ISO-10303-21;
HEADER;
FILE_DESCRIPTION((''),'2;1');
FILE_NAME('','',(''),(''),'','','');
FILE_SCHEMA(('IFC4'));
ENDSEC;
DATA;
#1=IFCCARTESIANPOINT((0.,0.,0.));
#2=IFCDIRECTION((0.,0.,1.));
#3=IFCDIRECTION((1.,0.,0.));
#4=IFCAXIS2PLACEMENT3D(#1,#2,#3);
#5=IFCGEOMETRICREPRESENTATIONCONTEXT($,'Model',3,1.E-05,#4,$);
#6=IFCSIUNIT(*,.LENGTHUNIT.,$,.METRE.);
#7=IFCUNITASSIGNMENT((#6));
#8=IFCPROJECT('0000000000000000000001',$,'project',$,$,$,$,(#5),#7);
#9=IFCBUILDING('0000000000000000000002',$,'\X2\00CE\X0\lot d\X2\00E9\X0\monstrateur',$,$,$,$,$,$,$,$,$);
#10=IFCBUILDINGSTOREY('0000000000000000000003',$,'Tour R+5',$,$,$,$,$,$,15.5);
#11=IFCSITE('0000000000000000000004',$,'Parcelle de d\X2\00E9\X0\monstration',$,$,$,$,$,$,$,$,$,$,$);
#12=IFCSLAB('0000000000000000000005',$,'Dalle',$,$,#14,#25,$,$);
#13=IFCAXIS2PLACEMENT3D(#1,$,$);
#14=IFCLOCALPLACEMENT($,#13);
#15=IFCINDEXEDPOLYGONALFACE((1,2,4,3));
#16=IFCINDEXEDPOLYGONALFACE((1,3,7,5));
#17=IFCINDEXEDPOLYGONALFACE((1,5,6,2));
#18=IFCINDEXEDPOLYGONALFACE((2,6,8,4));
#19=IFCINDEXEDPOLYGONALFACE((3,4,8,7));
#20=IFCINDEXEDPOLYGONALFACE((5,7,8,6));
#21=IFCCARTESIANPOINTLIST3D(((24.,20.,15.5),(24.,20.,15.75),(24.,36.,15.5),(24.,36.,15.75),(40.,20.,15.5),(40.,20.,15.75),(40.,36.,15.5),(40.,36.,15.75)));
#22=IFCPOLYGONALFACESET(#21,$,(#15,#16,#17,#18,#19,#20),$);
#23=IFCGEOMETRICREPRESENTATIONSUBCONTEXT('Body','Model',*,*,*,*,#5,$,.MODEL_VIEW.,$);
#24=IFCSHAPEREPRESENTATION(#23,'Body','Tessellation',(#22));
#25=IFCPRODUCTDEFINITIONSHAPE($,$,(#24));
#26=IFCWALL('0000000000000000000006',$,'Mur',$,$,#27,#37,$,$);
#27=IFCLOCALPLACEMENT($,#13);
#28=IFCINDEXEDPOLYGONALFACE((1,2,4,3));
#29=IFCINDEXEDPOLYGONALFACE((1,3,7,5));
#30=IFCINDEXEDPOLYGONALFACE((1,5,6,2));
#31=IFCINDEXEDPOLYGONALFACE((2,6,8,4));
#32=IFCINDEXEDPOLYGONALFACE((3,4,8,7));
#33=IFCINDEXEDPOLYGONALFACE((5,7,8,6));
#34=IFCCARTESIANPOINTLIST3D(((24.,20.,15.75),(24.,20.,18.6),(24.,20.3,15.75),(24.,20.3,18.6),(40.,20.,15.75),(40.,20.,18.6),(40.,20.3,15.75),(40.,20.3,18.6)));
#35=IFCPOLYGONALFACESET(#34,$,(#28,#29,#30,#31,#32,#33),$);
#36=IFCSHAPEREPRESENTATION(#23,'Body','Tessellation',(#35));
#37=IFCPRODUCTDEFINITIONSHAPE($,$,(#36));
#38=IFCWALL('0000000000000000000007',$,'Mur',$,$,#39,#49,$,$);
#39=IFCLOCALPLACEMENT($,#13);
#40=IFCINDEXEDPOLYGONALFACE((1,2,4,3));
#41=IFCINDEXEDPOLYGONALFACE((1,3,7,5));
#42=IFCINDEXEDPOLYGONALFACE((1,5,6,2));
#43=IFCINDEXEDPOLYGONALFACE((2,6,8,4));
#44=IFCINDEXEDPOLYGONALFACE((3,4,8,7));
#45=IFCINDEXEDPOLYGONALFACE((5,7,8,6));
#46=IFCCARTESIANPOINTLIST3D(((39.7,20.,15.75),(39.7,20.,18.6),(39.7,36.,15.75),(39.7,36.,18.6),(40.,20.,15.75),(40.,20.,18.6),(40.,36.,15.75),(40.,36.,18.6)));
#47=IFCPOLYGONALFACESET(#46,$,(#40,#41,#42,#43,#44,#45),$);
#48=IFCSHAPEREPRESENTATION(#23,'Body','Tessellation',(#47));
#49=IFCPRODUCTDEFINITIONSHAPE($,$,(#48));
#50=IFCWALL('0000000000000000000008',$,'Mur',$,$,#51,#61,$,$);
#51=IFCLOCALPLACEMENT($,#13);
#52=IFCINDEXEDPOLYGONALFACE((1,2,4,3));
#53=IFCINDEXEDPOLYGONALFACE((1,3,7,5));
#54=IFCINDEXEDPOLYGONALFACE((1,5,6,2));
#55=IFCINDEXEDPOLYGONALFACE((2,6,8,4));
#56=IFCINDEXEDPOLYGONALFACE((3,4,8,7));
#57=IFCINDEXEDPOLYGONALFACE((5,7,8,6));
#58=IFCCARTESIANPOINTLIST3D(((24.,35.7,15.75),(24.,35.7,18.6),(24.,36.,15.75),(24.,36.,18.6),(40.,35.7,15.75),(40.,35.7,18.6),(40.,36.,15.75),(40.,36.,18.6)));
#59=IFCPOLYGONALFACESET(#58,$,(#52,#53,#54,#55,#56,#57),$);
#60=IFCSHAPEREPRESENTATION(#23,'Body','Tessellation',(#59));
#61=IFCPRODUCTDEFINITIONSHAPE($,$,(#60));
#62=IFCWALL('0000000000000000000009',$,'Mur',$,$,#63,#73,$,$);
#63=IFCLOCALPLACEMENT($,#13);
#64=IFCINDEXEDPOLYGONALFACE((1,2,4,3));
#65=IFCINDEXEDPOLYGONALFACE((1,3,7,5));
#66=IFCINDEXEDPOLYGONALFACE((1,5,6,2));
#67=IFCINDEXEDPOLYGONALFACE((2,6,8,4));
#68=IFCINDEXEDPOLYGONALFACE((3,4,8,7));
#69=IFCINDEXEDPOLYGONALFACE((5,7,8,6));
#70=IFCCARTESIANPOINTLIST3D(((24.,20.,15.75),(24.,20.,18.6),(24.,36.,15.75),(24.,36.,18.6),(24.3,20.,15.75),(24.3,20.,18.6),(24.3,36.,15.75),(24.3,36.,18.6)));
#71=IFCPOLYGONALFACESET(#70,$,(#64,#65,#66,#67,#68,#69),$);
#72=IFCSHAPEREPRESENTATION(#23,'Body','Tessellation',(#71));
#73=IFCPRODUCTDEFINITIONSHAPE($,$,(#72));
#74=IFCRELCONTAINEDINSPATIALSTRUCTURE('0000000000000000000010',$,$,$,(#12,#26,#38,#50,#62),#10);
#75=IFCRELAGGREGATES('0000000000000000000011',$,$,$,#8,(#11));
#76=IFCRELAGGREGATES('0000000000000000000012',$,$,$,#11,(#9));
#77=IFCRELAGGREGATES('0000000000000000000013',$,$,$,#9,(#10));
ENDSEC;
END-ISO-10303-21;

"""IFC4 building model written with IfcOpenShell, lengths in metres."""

from ifc_helpers import new_model, si_unit, frame, origin_with_axes, place, context, subcontext, project, spatial, indexed_curve, outline, extrude, element, save


model = new_model("IFC4")

# Units and contexts
model_context = context("Model", 3, precision=1e-05, world=origin_with_axes())
body_context = subcontext(model_context, "Body", "Model", "MODEL_VIEW")
ifc_project = project(units=[si_unit("LENGTHUNIT", "METRE")], contexts=[model_context])

# Site, building, storey
site = spatial("IfcSite", under=ifc_project, Name="Parcelle de démonstration")
building = spatial("IfcBuilding", under=site, Name="Îlot démonstrateur")
storey = spatial("IfcBuildingStorey", under=building, Name="Tour R+5", Elevation=15.5)

# Slab
slab_placement = place(None, frame((0.0, 0.0, 15.5), z_axis=(0.0, 0.0, 1.0), x_axis=(1.0, 0.0, 0.0)))
element("IfcSlab", 1, at=slab_placement, inside=storey, Name="Dalle", context=body_context, shape_type="SweptSolid", body=[
    extrude(outline(indexed_curve([(24.0, 20.0), (40.0, 20.0), (40.0, 36.0), (24.0, 36.0)])), None, (0.0, 0.0, 1.0), 0.25),
])

# Walls
for number, where, z_axis, x_axis, name in (
    (2, (24.0, 20.0, 15.75), (0.0, 0.0, 1.0), (1.0, 0.0, 0.0), "Mur"),
    (3, (40.0, 20.0, 15.75), (0.0, 0.0, 1.0), (0.0, 1.0, 0.0), "Mur"),
    (4, (40.0, 36.0, 15.75), (0.0, 0.0, 1.0), (-1.0, 0.0, 0.0), "Mur"),
    (5, (24.0, 36.0, 15.75), (0.0, 0.0, 1.0), (0.0, -1.0, 0.0), "Mur"),
):
    element("IfcWall", number, at=place(None, frame(where, z_axis=z_axis, x_axis=x_axis)), inside=storey, Name=name, context=body_context, shape_type="SweptSolid", body=[
        extrude(outline(indexed_curve([(0.0, 0.0), (0.0, 0.3), (16.0, 0.3), (16.0, 0.0), (0.0, 0.0)], self_intersect=False)), origin_with_axes(), (0.0, 0.0, 1.0), 2.85),
    ])

save(model, "model.ifc")
